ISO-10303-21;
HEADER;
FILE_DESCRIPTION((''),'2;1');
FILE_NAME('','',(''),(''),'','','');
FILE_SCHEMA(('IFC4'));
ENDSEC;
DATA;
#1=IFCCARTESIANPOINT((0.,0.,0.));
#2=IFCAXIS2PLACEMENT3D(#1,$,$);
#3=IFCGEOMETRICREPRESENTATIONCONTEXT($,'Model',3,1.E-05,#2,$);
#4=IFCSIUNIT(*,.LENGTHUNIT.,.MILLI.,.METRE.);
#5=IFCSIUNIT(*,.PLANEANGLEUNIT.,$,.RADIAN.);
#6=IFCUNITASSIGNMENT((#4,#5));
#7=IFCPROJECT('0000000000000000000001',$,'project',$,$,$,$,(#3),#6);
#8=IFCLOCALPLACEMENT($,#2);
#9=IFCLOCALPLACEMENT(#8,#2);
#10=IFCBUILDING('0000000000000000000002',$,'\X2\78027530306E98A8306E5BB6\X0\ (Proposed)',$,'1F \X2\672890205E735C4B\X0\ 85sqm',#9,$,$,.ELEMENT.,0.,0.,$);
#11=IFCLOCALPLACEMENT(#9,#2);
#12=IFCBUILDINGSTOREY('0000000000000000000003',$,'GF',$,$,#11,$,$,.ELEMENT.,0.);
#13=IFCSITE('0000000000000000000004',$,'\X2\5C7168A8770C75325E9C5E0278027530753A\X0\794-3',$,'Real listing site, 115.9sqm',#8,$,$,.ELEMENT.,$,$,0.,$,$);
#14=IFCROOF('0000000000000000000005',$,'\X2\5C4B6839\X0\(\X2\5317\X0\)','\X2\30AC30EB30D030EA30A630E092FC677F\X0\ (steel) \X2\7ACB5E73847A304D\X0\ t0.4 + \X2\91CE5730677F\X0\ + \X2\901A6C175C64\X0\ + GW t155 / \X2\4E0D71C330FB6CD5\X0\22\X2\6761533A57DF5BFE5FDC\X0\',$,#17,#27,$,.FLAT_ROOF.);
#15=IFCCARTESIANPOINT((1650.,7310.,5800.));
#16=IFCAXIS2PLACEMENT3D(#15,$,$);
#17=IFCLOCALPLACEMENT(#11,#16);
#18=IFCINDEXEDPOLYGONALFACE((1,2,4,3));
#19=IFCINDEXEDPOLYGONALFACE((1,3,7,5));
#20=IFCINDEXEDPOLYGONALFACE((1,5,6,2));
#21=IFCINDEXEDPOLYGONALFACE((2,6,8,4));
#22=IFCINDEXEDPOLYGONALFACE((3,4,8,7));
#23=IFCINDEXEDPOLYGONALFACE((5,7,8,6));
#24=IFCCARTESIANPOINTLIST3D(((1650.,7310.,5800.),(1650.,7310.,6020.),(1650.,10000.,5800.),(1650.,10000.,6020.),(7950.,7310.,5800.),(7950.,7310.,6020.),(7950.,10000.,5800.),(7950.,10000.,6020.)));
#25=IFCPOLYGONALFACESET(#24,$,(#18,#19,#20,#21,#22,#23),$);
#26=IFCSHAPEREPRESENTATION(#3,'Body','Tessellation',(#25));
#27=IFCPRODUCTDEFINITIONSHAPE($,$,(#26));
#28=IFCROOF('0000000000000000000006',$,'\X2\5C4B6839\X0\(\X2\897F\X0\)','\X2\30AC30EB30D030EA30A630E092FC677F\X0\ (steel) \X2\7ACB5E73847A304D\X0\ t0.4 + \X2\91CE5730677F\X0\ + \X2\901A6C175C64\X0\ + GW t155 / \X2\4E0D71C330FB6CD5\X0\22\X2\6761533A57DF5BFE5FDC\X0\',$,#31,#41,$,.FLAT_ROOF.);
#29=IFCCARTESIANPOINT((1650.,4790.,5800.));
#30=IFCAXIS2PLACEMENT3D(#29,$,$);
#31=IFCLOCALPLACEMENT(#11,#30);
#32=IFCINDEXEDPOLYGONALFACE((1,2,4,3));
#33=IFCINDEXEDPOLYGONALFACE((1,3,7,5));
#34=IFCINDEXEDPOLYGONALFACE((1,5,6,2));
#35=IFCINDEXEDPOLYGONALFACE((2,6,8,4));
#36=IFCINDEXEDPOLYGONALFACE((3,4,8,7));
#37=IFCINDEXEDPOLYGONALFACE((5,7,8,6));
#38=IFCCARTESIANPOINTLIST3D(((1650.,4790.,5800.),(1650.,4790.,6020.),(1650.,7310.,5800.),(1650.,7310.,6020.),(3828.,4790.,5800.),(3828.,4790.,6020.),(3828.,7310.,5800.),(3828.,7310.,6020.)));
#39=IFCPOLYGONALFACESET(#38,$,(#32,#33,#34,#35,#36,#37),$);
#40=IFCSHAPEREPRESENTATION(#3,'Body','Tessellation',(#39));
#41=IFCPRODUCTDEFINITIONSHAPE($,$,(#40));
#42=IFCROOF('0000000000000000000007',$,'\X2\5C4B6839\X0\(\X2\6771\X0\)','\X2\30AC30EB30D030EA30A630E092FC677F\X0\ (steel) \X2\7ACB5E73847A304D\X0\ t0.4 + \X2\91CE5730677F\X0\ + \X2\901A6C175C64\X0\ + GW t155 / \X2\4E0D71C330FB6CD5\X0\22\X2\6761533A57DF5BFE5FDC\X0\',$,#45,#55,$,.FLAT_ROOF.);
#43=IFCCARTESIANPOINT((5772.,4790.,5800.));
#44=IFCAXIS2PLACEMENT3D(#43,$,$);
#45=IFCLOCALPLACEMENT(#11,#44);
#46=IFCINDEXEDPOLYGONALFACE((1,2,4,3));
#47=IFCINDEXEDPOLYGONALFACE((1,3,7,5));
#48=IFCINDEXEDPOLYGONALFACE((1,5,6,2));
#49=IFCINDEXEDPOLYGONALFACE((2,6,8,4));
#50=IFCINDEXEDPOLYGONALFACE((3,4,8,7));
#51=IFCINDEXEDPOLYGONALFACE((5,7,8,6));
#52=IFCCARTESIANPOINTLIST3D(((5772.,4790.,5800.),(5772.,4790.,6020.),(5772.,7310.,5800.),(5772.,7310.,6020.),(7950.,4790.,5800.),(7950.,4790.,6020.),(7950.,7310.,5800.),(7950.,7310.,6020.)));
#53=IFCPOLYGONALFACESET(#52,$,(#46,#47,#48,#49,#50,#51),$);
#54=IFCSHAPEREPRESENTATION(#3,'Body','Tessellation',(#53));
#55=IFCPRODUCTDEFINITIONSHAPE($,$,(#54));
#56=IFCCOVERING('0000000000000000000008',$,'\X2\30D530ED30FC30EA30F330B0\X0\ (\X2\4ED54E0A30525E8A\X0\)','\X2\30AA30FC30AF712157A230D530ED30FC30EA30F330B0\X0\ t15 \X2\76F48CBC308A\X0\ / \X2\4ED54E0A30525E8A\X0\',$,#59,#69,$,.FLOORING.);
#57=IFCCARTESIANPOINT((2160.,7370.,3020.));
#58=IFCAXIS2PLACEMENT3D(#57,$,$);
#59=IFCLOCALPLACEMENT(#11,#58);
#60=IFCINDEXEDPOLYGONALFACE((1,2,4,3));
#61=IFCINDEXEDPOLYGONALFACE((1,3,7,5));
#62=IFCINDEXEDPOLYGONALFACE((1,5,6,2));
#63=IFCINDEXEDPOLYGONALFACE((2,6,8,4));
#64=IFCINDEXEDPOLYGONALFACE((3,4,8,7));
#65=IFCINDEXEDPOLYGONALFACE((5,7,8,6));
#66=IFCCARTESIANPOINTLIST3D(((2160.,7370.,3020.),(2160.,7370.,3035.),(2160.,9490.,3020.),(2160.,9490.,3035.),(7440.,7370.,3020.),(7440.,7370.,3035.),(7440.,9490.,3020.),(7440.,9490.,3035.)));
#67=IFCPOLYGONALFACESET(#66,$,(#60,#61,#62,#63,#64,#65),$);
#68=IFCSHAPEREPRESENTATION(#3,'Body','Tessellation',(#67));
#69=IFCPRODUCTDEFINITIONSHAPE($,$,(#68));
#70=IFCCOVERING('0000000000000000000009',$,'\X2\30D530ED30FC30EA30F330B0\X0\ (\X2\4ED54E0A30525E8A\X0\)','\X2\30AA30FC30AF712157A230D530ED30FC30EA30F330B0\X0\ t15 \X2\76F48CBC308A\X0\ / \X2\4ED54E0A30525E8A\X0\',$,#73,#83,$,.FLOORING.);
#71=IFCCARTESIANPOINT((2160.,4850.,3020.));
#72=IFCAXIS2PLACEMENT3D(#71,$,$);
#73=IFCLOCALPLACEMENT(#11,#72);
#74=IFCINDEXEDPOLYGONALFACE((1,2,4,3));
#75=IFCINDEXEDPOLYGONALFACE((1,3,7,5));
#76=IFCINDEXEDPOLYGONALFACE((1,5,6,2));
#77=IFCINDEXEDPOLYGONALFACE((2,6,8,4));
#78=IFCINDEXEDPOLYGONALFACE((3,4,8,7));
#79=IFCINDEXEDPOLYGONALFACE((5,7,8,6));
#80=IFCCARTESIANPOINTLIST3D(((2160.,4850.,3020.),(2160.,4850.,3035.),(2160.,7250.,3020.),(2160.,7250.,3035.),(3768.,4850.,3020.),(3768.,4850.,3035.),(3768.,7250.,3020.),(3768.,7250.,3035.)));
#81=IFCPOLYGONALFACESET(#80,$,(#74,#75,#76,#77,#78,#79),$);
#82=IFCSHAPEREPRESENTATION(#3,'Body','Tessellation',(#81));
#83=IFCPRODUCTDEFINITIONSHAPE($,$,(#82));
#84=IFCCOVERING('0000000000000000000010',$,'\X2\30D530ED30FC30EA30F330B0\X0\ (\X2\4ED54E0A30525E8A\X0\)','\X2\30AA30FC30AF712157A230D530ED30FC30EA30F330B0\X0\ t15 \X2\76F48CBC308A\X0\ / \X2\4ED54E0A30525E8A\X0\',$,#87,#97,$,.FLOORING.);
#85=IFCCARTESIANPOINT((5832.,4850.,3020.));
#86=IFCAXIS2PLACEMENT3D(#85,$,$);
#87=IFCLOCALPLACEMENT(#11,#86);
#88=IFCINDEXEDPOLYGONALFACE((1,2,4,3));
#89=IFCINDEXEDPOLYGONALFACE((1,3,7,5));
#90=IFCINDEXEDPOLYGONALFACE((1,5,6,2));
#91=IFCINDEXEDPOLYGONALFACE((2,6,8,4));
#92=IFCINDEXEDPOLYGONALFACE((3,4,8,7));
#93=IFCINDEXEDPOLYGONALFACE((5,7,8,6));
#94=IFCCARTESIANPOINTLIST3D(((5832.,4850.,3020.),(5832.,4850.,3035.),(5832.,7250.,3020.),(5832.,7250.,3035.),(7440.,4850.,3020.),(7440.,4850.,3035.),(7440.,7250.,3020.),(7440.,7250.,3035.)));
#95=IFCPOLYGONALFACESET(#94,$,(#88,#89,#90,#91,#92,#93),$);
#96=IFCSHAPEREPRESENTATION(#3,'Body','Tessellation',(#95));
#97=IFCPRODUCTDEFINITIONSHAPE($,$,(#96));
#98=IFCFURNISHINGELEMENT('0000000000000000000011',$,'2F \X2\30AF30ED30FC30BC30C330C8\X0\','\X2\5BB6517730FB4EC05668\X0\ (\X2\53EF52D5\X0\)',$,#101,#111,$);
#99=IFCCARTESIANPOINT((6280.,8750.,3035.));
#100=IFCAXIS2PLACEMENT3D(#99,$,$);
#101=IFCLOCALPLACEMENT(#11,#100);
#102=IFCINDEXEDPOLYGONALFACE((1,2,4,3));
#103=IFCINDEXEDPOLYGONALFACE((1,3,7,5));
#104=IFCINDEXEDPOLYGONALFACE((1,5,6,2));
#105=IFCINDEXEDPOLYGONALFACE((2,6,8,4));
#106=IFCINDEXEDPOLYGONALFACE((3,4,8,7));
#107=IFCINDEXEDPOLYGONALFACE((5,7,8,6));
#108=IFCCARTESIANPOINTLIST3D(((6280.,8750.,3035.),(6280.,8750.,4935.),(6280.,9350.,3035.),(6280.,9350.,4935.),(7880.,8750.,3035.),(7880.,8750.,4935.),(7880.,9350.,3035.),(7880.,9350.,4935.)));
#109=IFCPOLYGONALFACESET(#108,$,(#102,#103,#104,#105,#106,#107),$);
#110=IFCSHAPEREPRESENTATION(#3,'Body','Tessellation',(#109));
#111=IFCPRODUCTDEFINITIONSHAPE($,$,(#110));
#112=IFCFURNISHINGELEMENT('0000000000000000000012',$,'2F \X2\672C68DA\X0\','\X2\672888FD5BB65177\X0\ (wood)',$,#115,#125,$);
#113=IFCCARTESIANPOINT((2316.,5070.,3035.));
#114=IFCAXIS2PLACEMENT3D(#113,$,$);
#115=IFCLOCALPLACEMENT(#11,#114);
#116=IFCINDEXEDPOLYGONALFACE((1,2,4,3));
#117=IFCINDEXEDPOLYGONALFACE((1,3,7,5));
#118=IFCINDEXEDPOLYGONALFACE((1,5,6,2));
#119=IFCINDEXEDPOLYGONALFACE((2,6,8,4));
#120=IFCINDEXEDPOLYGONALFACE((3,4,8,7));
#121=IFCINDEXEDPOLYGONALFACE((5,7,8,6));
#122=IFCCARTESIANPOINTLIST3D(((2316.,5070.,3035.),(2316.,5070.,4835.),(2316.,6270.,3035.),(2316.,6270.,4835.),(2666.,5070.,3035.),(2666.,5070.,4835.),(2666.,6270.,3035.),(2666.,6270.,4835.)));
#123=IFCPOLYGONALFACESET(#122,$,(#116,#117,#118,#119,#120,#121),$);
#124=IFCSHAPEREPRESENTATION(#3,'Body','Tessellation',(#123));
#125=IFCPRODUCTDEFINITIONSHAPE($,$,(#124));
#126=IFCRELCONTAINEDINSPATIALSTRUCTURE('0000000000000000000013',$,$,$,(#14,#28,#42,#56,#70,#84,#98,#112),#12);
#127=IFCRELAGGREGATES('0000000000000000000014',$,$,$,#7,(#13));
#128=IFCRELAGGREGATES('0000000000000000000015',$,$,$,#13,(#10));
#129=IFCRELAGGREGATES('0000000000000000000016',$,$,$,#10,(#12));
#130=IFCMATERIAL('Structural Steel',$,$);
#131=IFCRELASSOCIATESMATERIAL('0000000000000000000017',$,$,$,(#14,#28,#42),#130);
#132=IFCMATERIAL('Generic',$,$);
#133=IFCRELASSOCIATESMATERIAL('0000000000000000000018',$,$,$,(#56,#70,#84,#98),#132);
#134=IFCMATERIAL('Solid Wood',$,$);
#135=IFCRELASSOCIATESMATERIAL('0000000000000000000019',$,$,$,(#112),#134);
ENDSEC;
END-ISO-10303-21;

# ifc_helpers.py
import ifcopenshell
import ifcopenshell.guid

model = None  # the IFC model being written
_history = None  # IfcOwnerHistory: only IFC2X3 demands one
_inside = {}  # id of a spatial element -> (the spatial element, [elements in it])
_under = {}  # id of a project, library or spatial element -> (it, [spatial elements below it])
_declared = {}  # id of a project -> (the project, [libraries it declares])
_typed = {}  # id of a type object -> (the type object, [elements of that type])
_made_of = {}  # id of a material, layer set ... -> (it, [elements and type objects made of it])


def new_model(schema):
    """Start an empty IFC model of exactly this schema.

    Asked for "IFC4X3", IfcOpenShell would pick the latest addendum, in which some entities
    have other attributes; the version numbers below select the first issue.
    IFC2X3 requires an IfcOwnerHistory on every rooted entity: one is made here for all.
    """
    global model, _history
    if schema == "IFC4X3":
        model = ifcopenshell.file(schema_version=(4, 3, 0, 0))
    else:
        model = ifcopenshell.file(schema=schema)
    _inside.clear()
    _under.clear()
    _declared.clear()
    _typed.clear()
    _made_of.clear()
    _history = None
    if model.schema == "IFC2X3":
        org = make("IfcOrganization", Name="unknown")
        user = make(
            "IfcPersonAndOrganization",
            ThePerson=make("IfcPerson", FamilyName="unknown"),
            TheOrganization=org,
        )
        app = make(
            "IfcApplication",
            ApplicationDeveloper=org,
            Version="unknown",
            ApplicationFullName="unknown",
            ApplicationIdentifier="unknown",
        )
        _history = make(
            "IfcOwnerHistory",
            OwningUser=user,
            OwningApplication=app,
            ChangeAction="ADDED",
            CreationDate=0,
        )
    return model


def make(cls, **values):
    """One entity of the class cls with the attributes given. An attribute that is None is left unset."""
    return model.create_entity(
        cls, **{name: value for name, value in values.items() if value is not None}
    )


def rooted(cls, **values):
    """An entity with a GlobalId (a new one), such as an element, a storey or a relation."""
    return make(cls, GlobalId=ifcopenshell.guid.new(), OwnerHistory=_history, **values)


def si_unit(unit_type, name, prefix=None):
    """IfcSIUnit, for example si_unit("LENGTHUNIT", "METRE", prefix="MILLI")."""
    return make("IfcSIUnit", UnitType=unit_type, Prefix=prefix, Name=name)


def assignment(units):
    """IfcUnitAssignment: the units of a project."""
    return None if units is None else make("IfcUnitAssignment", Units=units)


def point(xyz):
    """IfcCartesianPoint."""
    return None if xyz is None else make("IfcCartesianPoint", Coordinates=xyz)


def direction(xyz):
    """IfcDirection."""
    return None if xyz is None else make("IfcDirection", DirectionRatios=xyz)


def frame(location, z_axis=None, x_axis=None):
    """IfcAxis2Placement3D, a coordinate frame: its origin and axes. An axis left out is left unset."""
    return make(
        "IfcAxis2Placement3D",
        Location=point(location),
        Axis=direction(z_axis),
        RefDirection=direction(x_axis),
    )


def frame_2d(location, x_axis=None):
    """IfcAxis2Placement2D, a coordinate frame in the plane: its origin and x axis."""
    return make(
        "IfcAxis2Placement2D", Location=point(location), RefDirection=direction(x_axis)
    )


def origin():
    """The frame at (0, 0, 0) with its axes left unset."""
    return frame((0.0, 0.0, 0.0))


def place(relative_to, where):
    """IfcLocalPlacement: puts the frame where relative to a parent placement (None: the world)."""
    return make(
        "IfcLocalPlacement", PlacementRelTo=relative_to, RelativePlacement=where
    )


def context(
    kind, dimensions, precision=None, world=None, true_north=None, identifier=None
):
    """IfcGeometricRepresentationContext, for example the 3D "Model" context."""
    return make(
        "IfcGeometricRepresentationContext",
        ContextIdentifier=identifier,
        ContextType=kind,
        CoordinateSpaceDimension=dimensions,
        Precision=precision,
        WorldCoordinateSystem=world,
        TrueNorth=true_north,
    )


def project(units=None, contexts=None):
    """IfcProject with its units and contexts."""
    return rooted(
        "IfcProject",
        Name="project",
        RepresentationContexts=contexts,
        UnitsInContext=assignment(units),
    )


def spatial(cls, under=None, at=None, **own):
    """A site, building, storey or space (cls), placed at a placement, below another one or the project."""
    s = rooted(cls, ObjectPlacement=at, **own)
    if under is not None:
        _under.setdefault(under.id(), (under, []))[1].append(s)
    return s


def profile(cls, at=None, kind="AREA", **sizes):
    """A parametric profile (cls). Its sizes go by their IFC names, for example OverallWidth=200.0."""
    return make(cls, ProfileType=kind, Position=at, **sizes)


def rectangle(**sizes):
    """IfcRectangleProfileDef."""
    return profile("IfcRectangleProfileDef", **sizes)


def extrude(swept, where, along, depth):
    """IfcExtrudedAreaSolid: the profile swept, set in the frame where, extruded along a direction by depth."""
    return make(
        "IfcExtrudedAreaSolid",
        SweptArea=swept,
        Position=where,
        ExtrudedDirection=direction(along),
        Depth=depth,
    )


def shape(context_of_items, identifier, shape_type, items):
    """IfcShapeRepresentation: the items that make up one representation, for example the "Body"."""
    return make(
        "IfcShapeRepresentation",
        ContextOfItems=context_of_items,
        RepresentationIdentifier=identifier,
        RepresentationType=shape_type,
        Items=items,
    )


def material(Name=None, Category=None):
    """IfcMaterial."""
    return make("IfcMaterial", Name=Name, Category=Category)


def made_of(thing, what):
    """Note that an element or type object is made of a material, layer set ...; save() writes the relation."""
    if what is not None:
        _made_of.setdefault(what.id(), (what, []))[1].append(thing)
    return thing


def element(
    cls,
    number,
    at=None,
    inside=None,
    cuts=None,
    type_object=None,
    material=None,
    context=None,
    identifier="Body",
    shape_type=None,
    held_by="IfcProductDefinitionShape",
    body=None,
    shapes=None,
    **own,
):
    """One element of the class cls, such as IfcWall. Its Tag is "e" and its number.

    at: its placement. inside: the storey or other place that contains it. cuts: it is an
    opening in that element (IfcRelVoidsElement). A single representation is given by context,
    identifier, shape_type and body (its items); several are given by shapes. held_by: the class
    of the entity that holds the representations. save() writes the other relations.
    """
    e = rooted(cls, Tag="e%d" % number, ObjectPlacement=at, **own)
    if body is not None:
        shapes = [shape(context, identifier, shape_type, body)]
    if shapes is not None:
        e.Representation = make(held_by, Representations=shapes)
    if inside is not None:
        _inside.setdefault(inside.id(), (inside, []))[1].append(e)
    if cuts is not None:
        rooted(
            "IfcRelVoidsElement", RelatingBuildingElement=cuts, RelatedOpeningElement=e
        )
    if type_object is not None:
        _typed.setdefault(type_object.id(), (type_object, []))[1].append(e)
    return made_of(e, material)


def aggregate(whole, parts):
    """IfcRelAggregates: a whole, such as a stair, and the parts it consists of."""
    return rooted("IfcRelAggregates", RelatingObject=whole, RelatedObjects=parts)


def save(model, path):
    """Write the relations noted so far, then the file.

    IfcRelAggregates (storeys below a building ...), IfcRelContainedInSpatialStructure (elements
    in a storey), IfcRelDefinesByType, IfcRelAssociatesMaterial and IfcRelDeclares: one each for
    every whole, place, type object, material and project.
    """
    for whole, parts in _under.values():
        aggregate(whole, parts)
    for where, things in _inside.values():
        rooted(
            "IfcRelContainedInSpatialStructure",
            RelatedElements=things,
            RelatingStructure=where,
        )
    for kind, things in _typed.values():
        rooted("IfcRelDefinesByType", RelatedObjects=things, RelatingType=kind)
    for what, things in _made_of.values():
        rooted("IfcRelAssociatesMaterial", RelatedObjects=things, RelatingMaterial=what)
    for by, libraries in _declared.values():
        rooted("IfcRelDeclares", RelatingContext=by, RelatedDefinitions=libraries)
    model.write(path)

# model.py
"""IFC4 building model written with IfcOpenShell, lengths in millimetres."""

from ifc_helpers import new_model, si_unit, frame, frame_2d, origin, place, context, project, spatial, rectangle, extrude, material, element, save


model = new_model("IFC4")

# Units and contexts
model_context = context("Model", 3, precision=1e-05, world=origin())
ifc_project = project(units=[si_unit("LENGTHUNIT", "METRE", prefix="MILLI"), si_unit("PLANEANGLEUNIT", "RADIAN")], contexts=[model_context])

# Site, building, storey
site_placement = place(None, origin())
site = spatial("IfcSite", under=ifc_project, at=site_placement, Name="山梨県甲府市砂田町794-3", ObjectType="Real listing site, 115.9sqm", CompositionType="ELEMENT", RefElevation=0.0)
building_placement = place(site_placement, origin())
building = spatial("IfcBuilding", under=site, at=building_placement, Name="砂田の風の家 (Proposed)", ObjectType="1F 木造平屋 85sqm", CompositionType="ELEMENT", ElevationOfRefHeight=0.0, ElevationOfTerrain=0.0)
storey_placement = place(building_placement, origin())
storey = spatial("IfcBuildingStorey", under=building, at=storey_placement, Name="GF", CompositionType="ELEMENT", Elevation=0.0)

# Shared definitions
ifc_material_1 = material(Name="Solid Wood")

# Shared definitions
ifc_material_2 = material(Name="Generic")

# Roofs
ifc_material_3 = material(Name="Structural Steel")
for number, where, name in (
    (1, (1650.0, 7310.0, 5800.0), "屋根(北)"),
):
    element("IfcRoof", number, at=place(storey_placement, frame(where)), inside=storey, material=ifc_material_3, Name=name, Description="ガルバリウム鋼板 (steel) 立平葺き t0.4 + 野地板 + 通気層 + GW t155 / 不燃・法22条区域対応", PredefinedType="FLAT_ROOF", context=model_context, shape_type="SweptSolid", body=[
        extrude(rectangle(XDim=6300.0, YDim=2690.0, at=frame_2d((3150.0, 1345.0))), frame((1650.0, 7310.0, 5800.0)), (0.0, 0.0, 1.0), 220.0),
    ])
roof_1_placement = place(storey_placement, frame((1650.0, 4790.0, 5800.0)))
element("IfcRoof", 2, at=roof_1_placement, inside=storey, material=ifc_material_3, Name="屋根(西)", Description="ガルバリウム鋼板 (steel) 立平葺き t0.4 + 野地板 + 通気層 + GW t155 / 不燃・法22条区域対応", PredefinedType="FLAT_ROOF", context=model_context, shape_type="SweptSolid", body=[
    extrude(rectangle(XDim=2178.0, YDim=2520.0, at=frame_2d((1089.0, 1260.0))), frame((1650.0, 4790.0, 5800.0)), (0.0, 0.0, 1.0), 220.0),
])
roof_2_placement = place(storey_placement, frame((5772.0, 4790.0, 5800.0)))
element("IfcRoof", 3, at=roof_2_placement, inside=storey, material=ifc_material_3, Name="屋根(東)", Description="ガルバリウム鋼板 (steel) 立平葺き t0.4 + 野地板 + 通気層 + GW t155 / 不燃・法22条区域対応", PredefinedType="FLAT_ROOF", context=model_context, shape_type="SweptSolid", body=[
    extrude(rectangle(XDim=2178.0, YDim=2520.0, at=frame_2d((1089.0, 1260.0))), frame((5772.0, 4790.0, 5800.0)), (0.0, 0.0, 1.0), 220.0),
])

# Coverings
covering_1_placement = place(storey_placement, frame((2160.0, 7370.0, 3020.0)))
element("IfcCovering", 4, at=covering_1_placement, inside=storey, material=ifc_material_2, Name="フローリング (仕上げ床)", Description="オーク無垢フローリング t15 直貼り / 仕上げ床", PredefinedType="FLOORING", context=model_context, shape_type="SweptSolid", body=[
    extrude(rectangle(XDim=5280.0, YDim=2120.0, at=frame_2d((2640.0, 1060.0))), frame((2160.0, 7370.0, 3020.0)), (0.0, 0.0, 1.0), 15.0),
])
covering_2_placement = place(storey_placement, frame((2160.0, 4850.0, 3020.0)))
element("IfcCovering", 5, at=covering_2_placement, inside=storey, material=ifc_material_2, Name="フローリング (仕上げ床)", Description="オーク無垢フローリング t15 直貼り / 仕上げ床", PredefinedType="FLOORING", context=model_context, shape_type="SweptSolid", body=[
    extrude(rectangle(XDim=1608.0, YDim=2400.0, at=frame_2d((804.0, 1200.0))), frame((2160.0, 4850.0, 3020.0)), (0.0, 0.0, 1.0), 15.0),
])
covering_3_placement = place(storey_placement, frame((5832.0, 4850.0, 3020.0)))
element("IfcCovering", 6, at=covering_3_placement, inside=storey, material=ifc_material_2, Name="フローリング (仕上げ床)", Description="オーク無垢フローリング t15 直貼り / 仕上げ床", PredefinedType="FLOORING", context=model_context, shape_type="SweptSolid", body=[
    extrude(rectangle(XDim=1608.0, YDim=2400.0, at=frame_2d((804.0, 1200.0))), frame((5832.0, 4850.0, 3020.0)), (0.0, 0.0, 1.0), 15.0),
])

# Furnishing elements
furnishing_1_placement = place(storey_placement, frame((6280.0, 8750.0, 3035.0)))
element("IfcFurnishingElement", 7, at=furnishing_1_placement, inside=storey, material=ifc_material_2, Name="2F クローゼット", Description="家具・什器 (可動)", context=model_context, shape_type="SweptSolid", body=[
    extrude(rectangle(XDim=1600.0, YDim=600.0, at=frame_2d((800.0, 300.0))), frame((6280.0, 8750.0, 3035.0)), (0.0, 0.0, 1.0), 1900.0),
])
furnishing_2_placement = place(storey_placement, frame((2316.0, 5070.0, 3035.0)))
element("IfcFurnishingElement", 8, at=furnishing_2_placement, inside=storey, material=ifc_material_1, Name="2F 本棚", Description="木製家具 (wood)", context=model_context, shape_type="SweptSolid", body=[
    extrude(rectangle(XDim=350.0, YDim=1200.0, at=frame_2d((175.0, 600.0))), frame((2316.0, 5070.0, 3035.0)), (0.0, 0.0, 1.0), 1800.0),
])

save(model, "model.ifc")
